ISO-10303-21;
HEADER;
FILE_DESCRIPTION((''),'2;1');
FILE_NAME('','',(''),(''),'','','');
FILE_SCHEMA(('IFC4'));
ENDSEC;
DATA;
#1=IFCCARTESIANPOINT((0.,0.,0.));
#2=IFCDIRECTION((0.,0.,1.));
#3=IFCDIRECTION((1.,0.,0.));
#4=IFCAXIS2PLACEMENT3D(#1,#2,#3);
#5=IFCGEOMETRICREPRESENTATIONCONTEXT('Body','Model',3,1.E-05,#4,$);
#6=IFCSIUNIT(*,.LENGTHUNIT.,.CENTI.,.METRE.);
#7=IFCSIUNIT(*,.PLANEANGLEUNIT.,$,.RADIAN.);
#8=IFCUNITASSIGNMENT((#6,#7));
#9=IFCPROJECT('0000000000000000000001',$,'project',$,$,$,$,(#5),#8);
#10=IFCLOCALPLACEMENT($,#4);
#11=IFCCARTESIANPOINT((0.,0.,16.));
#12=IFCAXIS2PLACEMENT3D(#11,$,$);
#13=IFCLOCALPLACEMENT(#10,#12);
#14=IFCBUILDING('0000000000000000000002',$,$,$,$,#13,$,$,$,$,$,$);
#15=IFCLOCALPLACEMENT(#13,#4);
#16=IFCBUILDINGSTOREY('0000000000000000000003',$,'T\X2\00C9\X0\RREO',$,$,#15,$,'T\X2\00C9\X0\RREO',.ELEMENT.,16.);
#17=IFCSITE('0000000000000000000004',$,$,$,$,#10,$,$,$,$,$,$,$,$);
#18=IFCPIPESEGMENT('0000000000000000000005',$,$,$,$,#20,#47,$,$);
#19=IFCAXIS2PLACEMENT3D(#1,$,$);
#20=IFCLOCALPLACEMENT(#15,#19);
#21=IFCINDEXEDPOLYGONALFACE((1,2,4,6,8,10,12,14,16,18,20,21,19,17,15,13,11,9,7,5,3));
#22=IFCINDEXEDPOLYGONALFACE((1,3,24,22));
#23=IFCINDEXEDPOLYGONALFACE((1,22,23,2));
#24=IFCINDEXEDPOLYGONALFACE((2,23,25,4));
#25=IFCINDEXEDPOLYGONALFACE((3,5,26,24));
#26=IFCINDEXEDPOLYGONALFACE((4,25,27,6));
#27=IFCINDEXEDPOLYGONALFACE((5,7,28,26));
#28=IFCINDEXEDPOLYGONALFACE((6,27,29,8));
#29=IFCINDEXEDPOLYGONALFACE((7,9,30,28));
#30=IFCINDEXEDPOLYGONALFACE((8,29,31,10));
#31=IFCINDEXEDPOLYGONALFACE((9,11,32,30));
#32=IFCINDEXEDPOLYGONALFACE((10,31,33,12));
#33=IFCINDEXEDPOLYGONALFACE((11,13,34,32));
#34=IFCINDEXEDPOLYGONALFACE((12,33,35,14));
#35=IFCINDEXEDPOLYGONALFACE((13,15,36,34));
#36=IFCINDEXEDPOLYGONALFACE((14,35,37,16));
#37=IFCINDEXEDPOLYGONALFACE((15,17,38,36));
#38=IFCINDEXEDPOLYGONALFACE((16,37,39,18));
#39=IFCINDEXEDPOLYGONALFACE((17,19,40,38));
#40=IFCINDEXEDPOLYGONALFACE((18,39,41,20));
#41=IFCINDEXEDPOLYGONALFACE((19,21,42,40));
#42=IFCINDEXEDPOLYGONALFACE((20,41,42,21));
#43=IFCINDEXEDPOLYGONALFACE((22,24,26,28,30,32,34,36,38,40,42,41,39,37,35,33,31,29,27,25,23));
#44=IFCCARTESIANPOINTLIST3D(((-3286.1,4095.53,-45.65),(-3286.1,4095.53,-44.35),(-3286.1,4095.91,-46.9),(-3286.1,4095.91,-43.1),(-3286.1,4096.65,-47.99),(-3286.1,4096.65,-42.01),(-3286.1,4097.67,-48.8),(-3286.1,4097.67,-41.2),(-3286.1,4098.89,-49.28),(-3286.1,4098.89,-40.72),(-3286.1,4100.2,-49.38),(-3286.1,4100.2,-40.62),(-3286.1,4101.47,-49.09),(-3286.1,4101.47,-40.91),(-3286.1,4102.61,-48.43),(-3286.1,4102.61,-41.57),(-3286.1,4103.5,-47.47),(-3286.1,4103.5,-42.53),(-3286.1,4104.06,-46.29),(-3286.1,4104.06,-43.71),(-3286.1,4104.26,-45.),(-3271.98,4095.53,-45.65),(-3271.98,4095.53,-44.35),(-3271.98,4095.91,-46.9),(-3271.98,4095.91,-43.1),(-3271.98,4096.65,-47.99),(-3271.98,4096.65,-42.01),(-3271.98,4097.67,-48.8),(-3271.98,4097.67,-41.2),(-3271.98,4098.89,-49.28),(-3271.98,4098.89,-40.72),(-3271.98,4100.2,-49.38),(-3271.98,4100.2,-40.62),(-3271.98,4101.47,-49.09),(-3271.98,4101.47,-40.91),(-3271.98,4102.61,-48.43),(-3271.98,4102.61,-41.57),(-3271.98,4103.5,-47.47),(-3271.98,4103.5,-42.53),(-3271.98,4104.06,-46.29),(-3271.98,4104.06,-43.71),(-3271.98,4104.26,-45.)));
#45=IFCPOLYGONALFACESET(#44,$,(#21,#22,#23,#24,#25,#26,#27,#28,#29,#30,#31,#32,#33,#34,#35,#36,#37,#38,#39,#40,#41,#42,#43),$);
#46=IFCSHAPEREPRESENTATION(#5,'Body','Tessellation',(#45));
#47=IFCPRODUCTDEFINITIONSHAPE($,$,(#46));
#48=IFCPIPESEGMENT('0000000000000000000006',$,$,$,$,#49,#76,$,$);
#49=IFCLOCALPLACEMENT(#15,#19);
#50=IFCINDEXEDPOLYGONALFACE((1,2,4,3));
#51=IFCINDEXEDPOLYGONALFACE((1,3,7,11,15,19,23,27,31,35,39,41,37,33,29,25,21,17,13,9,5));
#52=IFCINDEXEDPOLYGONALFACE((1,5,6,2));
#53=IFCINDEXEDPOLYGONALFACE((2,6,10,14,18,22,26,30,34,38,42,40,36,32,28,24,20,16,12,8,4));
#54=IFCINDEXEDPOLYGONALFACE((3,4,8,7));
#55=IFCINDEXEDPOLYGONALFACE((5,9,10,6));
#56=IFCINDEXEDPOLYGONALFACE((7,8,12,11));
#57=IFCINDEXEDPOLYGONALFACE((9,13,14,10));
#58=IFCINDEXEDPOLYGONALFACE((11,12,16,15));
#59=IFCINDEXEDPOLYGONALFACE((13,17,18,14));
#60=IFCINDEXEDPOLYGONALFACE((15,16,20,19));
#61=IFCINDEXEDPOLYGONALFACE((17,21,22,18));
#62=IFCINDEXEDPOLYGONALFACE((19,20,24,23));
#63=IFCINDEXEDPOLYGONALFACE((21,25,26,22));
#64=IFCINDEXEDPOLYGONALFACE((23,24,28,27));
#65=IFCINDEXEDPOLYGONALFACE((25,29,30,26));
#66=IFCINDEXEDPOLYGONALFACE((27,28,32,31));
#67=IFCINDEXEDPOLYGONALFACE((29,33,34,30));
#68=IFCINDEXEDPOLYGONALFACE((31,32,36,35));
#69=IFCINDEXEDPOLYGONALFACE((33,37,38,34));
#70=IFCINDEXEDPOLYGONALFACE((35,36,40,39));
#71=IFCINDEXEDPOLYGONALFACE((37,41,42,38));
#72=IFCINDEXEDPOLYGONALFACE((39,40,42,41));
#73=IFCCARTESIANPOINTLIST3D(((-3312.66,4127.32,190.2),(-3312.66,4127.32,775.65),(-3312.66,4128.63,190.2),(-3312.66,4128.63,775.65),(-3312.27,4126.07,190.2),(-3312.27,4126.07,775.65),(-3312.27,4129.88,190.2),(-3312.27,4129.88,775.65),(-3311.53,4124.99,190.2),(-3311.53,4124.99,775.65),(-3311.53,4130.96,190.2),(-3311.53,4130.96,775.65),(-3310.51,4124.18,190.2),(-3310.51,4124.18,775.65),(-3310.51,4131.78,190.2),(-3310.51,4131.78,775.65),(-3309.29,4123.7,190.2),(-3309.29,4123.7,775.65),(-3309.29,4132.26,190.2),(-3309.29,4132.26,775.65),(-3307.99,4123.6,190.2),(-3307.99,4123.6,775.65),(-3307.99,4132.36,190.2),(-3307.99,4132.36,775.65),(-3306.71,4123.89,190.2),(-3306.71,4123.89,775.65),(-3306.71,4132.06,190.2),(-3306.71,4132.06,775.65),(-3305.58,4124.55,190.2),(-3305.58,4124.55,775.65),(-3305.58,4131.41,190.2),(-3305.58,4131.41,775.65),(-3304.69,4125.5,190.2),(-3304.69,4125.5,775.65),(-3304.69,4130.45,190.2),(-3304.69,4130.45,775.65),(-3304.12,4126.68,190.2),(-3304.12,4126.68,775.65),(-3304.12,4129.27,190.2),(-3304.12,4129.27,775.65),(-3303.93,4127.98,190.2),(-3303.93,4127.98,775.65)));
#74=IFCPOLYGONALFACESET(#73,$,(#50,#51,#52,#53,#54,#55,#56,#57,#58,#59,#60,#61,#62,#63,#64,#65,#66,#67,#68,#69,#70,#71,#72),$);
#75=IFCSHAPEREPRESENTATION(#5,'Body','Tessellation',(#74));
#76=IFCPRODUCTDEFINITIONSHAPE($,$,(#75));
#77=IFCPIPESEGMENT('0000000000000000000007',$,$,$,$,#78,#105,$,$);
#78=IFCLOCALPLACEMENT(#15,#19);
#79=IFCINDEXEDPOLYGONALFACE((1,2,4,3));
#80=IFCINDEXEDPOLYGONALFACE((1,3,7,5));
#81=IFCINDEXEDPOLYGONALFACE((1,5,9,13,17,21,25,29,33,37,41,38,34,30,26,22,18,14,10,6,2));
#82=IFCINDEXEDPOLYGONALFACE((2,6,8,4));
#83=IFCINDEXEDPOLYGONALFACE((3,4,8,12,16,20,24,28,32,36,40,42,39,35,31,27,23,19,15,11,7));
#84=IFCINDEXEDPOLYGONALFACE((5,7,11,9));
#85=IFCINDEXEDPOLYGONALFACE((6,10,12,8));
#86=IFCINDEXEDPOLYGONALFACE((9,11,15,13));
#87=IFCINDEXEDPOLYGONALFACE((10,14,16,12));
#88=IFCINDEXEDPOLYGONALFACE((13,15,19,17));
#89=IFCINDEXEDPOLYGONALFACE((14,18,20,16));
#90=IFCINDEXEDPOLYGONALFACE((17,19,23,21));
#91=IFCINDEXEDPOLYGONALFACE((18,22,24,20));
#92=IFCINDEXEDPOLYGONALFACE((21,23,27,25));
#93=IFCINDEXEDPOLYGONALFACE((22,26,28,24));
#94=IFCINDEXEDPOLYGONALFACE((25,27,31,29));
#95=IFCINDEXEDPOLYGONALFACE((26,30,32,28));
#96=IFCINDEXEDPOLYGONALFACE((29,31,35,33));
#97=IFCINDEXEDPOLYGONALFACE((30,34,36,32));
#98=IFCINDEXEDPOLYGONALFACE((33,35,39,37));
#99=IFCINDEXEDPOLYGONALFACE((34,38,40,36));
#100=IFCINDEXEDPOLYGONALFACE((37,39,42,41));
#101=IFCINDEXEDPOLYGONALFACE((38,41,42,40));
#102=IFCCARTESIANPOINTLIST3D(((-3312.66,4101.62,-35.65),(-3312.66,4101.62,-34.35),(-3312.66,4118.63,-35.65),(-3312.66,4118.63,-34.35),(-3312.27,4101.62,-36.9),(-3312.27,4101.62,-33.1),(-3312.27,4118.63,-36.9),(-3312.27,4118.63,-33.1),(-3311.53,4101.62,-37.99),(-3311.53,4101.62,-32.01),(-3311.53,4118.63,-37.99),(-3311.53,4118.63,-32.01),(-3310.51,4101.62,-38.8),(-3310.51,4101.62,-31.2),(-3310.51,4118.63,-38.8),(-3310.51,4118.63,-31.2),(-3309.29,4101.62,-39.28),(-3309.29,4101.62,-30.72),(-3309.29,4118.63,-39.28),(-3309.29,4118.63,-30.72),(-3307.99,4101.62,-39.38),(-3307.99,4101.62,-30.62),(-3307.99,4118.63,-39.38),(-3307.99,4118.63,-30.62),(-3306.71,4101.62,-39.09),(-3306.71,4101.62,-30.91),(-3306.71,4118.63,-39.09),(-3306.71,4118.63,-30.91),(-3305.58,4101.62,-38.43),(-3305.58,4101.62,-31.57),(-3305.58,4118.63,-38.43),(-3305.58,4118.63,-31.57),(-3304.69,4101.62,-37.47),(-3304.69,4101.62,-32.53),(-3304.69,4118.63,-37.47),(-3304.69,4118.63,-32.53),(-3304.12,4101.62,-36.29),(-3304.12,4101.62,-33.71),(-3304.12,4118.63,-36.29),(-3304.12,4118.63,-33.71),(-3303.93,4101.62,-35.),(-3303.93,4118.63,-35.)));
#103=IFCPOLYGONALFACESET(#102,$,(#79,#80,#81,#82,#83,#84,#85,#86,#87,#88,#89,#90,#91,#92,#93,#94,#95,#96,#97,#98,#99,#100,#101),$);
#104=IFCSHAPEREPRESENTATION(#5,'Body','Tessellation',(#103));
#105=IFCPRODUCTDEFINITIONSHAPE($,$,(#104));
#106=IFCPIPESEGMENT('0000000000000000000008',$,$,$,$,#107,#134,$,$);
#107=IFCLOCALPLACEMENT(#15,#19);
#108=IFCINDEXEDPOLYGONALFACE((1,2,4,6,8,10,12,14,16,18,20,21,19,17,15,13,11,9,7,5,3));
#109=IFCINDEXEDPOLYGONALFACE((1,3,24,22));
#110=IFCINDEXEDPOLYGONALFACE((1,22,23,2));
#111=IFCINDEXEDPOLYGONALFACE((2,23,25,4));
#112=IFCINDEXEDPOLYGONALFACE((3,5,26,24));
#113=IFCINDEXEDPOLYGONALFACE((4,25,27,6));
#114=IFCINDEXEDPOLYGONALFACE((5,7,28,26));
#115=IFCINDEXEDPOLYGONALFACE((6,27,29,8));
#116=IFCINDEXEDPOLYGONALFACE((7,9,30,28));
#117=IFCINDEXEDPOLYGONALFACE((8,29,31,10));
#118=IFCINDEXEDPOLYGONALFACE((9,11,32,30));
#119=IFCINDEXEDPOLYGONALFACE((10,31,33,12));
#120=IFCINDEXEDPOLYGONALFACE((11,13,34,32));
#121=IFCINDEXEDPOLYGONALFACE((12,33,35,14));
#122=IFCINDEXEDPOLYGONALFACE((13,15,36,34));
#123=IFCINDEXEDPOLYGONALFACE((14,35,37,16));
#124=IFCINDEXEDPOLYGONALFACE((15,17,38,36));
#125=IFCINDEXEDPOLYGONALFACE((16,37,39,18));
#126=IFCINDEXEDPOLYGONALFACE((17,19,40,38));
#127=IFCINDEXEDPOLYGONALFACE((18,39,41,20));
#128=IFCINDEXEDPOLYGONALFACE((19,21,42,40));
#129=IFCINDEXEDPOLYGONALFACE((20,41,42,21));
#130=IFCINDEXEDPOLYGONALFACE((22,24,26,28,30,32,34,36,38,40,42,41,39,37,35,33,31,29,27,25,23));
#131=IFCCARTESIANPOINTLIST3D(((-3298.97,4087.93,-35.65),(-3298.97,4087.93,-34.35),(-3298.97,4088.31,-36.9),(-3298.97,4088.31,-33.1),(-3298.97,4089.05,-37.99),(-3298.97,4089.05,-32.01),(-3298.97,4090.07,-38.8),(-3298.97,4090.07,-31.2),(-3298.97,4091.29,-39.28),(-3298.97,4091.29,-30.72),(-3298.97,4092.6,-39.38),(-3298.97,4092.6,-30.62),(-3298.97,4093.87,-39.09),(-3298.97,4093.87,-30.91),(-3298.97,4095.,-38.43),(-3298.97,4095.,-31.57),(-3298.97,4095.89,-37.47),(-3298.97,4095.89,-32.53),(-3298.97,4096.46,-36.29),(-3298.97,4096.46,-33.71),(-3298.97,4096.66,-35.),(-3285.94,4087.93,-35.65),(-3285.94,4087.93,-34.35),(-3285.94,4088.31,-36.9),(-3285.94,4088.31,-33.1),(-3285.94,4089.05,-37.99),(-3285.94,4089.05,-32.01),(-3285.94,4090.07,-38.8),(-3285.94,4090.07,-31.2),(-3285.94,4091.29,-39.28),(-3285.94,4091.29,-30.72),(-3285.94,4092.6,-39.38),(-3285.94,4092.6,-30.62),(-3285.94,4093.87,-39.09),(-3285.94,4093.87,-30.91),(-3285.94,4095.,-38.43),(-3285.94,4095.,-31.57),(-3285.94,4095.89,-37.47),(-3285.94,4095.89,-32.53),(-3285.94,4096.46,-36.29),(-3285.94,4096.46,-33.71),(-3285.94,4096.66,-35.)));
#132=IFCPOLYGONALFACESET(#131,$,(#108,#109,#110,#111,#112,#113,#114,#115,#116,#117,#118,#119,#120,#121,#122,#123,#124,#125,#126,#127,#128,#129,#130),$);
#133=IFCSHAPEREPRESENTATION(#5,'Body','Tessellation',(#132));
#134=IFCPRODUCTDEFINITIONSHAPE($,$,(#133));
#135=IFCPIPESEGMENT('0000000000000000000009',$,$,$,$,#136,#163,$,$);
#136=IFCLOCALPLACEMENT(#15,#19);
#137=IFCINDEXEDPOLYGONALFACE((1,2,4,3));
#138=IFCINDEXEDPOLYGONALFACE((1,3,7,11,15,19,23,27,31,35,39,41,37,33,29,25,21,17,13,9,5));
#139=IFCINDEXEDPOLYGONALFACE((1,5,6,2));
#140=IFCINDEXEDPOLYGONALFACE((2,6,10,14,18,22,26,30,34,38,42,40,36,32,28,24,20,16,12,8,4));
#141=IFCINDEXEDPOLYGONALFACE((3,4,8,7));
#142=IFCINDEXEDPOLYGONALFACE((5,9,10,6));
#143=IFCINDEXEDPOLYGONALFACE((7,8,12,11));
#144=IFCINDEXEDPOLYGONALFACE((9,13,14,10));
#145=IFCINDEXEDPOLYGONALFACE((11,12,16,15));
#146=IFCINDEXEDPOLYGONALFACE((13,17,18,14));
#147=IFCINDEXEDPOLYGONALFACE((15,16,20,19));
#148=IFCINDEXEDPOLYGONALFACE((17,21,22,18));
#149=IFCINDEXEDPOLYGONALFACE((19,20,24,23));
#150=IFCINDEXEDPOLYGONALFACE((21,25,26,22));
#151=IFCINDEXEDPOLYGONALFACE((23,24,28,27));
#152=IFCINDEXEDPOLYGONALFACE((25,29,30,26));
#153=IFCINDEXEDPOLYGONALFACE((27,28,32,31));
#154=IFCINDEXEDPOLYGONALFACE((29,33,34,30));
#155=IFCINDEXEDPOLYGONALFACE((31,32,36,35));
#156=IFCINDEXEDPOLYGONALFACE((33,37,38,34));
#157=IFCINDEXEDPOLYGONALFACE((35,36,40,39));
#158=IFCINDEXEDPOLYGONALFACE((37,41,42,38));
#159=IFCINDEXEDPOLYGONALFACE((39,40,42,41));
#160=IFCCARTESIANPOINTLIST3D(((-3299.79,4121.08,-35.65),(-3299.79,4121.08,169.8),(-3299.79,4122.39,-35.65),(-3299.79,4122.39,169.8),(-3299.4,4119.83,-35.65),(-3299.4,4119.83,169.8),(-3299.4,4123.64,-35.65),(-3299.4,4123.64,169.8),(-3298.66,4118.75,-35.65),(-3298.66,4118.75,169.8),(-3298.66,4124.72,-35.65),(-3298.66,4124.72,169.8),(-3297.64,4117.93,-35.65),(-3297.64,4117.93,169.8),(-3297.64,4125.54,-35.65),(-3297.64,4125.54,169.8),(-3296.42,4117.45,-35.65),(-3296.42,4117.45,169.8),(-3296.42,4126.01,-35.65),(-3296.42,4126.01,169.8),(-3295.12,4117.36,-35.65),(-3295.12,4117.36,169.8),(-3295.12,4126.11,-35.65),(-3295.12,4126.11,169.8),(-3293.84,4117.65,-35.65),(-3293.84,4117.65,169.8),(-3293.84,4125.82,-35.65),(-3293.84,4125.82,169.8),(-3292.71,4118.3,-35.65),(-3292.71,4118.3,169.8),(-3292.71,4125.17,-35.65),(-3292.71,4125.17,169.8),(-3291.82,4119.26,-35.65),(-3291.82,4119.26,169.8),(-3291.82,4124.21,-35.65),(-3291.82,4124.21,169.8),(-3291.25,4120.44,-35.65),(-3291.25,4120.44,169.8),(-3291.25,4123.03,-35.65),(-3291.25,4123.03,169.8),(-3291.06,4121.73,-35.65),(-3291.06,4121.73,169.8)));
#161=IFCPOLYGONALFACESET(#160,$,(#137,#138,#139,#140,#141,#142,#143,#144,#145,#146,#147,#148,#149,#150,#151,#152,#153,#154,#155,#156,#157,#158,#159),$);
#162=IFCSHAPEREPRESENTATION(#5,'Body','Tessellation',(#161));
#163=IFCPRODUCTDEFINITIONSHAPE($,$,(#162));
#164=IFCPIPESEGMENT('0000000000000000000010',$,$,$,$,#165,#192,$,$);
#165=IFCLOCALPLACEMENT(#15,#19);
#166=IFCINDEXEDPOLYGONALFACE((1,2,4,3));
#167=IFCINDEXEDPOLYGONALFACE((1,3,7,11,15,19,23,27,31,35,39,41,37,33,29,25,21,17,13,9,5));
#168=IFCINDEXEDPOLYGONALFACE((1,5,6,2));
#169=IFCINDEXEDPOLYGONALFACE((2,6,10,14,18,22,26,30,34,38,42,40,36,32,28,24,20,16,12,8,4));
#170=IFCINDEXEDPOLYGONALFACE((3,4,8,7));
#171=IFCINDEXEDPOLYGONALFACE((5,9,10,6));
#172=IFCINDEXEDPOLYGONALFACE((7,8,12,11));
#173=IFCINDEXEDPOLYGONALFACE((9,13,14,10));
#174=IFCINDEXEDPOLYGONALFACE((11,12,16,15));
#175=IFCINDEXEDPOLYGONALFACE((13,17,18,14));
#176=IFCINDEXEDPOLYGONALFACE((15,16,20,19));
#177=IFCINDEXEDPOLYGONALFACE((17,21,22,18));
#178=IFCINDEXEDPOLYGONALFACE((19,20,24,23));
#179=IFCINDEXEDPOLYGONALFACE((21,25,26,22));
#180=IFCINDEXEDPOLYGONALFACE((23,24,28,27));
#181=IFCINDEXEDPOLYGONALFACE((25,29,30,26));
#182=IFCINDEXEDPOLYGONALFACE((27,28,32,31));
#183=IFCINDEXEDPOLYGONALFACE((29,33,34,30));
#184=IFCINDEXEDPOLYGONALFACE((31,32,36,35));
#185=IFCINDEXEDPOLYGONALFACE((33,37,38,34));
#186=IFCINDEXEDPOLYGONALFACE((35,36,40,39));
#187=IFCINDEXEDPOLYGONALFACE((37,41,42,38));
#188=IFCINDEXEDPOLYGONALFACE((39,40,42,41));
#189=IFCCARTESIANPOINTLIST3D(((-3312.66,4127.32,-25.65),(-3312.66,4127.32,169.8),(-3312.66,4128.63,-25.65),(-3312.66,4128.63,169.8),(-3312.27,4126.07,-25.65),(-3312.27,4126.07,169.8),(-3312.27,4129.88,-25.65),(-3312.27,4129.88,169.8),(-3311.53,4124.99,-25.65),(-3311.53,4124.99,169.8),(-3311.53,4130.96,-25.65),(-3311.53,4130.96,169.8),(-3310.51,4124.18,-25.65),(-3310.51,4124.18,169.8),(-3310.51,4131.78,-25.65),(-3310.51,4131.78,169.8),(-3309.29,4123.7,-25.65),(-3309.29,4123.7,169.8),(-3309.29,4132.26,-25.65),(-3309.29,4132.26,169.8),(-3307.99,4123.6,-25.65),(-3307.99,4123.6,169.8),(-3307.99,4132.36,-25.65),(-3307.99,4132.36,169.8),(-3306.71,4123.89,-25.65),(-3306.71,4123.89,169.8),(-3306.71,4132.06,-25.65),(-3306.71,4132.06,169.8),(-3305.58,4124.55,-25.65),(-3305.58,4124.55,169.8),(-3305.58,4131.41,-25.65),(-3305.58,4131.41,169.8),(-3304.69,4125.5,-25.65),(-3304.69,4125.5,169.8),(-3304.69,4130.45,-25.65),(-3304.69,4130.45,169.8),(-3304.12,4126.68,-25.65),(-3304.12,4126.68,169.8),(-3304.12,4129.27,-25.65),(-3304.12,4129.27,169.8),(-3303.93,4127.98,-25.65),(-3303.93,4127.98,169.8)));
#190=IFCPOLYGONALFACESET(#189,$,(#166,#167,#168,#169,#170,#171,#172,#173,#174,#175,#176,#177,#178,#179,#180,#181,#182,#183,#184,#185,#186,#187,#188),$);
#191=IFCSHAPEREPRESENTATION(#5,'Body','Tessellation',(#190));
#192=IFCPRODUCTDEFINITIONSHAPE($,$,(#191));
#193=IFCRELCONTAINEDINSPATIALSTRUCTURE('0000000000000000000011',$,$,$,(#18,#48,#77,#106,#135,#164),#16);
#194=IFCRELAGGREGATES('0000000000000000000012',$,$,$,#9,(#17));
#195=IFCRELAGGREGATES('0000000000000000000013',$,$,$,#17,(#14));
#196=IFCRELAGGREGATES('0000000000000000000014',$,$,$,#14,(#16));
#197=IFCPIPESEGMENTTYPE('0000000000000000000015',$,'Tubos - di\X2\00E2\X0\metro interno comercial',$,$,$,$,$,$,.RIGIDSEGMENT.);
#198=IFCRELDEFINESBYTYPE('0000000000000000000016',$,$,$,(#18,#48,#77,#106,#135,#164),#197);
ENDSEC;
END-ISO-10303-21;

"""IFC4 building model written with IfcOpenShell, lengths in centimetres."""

from ifc_helpers import new_model, si_unit, frame, origin_with_axes, origin_2d_with_axis, place, context, project, spatial, circle, extrude, type_object, element, save


model = new_model("IFC4")

# Units and contexts
model_context = context("Model", 3, precision=1e-05, world=origin_with_axes(), identifier="Body")
ifc_project = project(units=[si_unit("LENGTHUNIT", "METRE", prefix="CENTI"), si_unit("PLANEANGLEUNIT", "RADIAN")], contexts=[model_context])

# Site, building, storey
site_placement = place(None, origin_with_axes())
site = spatial("IfcSite", under=ifc_project, at=site_placement)
building_placement = place(site_placement, frame((0.0, 0.0, 16.0)))
building = spatial("IfcBuilding", under=site, at=building_placement)
storey_placement = place(building_placement, origin_with_axes())
storey = spatial("IfcBuildingStorey", under=building, at=storey_placement, Name="TÉRREO", LongName="TÉRREO", CompositionType="ELEMENT", Elevation=16.0)

# Pipe segments
pipe_segment_type = type_object("IfcPipeSegmentType", Name="Tubos - diâmetro interno comercial", PredefinedType="RIGIDSEGMENT")
pipe_segment_1_placement = place(storey_placement, frame((-3279.04, 4099.87, -40.61), z_axis=(0.0, 0.0, 1.0), x_axis=(1.0, 0.0, 0.0)))
element("IfcPipeSegment", 1, at=pipe_segment_1_placement, inside=storey, type_object=pipe_segment_type, context=model_context, shape_type="SolidModel", body=[
    extrude(circle(Radius=4.39, at=origin_2d_with_axis()), frame((-7.06, 0.0, -4.39), z_axis=(1.0, 0.0, 0.0), x_axis=(0.0, 1.0, 0.0)), (0.0, 0.0, 1.0), 14.12),
])
pipe_segment_2_placement = place(storey_placement, frame((-3308.32, 4127.98, 775.65), z_axis=(0.0, 0.0, 1.0), x_axis=(1.0, 0.0, 0.0)))
element("IfcPipeSegment", 2, at=pipe_segment_2_placement, inside=storey, type_object=pipe_segment_type, context=model_context, shape_type="SolidModel", body=[
    extrude(circle(Radius=4.39, at=origin_2d_with_axis()), frame((0.0, 0.0, 0.0), z_axis=(0.0, 0.0, -1.0), x_axis=(1.0, 0.0, 0.0)), (0.0, 0.0, 1.0), 585.45),
])
pipe_segment_3_placement = place(storey_placement, frame((-3308.32, 4110.12, -30.61), z_axis=(0.0, 0.0, 1.0), x_axis=(1.0, 0.0, 0.0)))
element("IfcPipeSegment", 3, at=pipe_segment_3_placement, inside=storey, type_object=pipe_segment_type, context=model_context, shape_type="SolidModel", body=[
    extrude(circle(Radius=4.39, at=origin_2d_with_axis()), frame((0.0, 8.51, -4.39), z_axis=(0.0, -1.0, 0.0), x_axis=(1.0, 0.0, 0.0)), (0.0, 0.0, 1.0), 17.01),
])
pipe_segment_4_placement = place(storey_placement, frame((-3292.45, 4092.27, -30.61), z_axis=(0.0, 0.0, 1.0), x_axis=(1.0, 0.0, 0.0)))
element("IfcPipeSegment", 4, at=pipe_segment_4_placement, inside=storey, type_object=pipe_segment_type, context=model_context, shape_type="SolidModel", body=[
    extrude(circle(Radius=4.39, at=origin_2d_with_axis()), frame((-6.51, 0.0, -4.39), z_axis=(1.0, 0.0, 0.0), x_axis=(0.0, 1.0, 0.0)), (0.0, 0.0, 1.0), 13.02),
])
pipe_segment_5_placement = place(storey_placement, frame((-3295.45, 4121.73, 169.8), z_axis=(0.0, 0.0, 1.0), x_axis=(1.0, 0.0, 0.0)))
element("IfcPipeSegment", 5, at=pipe_segment_5_placement, inside=storey, type_object=pipe_segment_type, context=model_context, shape_type="SolidModel", body=[
    extrude(circle(Radius=4.39, at=origin_2d_with_axis()), frame((0.0, 0.0, 0.0), z_axis=(0.0, 0.0, -1.0), x_axis=(1.0, 0.0, 0.0)), (0.0, 0.0, 1.0), 205.45),
])
pipe_segment_6_placement = place(storey_placement, frame((-3308.32, 4127.98, 169.8), z_axis=(0.0, 0.0, 1.0), x_axis=(1.0, 0.0, 0.0)))
element("IfcPipeSegment", 6, at=pipe_segment_6_placement, inside=storey, type_object=pipe_segment_type, context=model_context, shape_type="SolidModel", body=[
    extrude(circle(Radius=4.39, at=origin_2d_with_axis()), frame((0.0, 0.0, 0.0), z_axis=(0.0, 0.0, -1.0), x_axis=(1.0, 0.0, 0.0)), (0.0, 0.0, 1.0), 195.45),
])

save(model, "model.ifc")
